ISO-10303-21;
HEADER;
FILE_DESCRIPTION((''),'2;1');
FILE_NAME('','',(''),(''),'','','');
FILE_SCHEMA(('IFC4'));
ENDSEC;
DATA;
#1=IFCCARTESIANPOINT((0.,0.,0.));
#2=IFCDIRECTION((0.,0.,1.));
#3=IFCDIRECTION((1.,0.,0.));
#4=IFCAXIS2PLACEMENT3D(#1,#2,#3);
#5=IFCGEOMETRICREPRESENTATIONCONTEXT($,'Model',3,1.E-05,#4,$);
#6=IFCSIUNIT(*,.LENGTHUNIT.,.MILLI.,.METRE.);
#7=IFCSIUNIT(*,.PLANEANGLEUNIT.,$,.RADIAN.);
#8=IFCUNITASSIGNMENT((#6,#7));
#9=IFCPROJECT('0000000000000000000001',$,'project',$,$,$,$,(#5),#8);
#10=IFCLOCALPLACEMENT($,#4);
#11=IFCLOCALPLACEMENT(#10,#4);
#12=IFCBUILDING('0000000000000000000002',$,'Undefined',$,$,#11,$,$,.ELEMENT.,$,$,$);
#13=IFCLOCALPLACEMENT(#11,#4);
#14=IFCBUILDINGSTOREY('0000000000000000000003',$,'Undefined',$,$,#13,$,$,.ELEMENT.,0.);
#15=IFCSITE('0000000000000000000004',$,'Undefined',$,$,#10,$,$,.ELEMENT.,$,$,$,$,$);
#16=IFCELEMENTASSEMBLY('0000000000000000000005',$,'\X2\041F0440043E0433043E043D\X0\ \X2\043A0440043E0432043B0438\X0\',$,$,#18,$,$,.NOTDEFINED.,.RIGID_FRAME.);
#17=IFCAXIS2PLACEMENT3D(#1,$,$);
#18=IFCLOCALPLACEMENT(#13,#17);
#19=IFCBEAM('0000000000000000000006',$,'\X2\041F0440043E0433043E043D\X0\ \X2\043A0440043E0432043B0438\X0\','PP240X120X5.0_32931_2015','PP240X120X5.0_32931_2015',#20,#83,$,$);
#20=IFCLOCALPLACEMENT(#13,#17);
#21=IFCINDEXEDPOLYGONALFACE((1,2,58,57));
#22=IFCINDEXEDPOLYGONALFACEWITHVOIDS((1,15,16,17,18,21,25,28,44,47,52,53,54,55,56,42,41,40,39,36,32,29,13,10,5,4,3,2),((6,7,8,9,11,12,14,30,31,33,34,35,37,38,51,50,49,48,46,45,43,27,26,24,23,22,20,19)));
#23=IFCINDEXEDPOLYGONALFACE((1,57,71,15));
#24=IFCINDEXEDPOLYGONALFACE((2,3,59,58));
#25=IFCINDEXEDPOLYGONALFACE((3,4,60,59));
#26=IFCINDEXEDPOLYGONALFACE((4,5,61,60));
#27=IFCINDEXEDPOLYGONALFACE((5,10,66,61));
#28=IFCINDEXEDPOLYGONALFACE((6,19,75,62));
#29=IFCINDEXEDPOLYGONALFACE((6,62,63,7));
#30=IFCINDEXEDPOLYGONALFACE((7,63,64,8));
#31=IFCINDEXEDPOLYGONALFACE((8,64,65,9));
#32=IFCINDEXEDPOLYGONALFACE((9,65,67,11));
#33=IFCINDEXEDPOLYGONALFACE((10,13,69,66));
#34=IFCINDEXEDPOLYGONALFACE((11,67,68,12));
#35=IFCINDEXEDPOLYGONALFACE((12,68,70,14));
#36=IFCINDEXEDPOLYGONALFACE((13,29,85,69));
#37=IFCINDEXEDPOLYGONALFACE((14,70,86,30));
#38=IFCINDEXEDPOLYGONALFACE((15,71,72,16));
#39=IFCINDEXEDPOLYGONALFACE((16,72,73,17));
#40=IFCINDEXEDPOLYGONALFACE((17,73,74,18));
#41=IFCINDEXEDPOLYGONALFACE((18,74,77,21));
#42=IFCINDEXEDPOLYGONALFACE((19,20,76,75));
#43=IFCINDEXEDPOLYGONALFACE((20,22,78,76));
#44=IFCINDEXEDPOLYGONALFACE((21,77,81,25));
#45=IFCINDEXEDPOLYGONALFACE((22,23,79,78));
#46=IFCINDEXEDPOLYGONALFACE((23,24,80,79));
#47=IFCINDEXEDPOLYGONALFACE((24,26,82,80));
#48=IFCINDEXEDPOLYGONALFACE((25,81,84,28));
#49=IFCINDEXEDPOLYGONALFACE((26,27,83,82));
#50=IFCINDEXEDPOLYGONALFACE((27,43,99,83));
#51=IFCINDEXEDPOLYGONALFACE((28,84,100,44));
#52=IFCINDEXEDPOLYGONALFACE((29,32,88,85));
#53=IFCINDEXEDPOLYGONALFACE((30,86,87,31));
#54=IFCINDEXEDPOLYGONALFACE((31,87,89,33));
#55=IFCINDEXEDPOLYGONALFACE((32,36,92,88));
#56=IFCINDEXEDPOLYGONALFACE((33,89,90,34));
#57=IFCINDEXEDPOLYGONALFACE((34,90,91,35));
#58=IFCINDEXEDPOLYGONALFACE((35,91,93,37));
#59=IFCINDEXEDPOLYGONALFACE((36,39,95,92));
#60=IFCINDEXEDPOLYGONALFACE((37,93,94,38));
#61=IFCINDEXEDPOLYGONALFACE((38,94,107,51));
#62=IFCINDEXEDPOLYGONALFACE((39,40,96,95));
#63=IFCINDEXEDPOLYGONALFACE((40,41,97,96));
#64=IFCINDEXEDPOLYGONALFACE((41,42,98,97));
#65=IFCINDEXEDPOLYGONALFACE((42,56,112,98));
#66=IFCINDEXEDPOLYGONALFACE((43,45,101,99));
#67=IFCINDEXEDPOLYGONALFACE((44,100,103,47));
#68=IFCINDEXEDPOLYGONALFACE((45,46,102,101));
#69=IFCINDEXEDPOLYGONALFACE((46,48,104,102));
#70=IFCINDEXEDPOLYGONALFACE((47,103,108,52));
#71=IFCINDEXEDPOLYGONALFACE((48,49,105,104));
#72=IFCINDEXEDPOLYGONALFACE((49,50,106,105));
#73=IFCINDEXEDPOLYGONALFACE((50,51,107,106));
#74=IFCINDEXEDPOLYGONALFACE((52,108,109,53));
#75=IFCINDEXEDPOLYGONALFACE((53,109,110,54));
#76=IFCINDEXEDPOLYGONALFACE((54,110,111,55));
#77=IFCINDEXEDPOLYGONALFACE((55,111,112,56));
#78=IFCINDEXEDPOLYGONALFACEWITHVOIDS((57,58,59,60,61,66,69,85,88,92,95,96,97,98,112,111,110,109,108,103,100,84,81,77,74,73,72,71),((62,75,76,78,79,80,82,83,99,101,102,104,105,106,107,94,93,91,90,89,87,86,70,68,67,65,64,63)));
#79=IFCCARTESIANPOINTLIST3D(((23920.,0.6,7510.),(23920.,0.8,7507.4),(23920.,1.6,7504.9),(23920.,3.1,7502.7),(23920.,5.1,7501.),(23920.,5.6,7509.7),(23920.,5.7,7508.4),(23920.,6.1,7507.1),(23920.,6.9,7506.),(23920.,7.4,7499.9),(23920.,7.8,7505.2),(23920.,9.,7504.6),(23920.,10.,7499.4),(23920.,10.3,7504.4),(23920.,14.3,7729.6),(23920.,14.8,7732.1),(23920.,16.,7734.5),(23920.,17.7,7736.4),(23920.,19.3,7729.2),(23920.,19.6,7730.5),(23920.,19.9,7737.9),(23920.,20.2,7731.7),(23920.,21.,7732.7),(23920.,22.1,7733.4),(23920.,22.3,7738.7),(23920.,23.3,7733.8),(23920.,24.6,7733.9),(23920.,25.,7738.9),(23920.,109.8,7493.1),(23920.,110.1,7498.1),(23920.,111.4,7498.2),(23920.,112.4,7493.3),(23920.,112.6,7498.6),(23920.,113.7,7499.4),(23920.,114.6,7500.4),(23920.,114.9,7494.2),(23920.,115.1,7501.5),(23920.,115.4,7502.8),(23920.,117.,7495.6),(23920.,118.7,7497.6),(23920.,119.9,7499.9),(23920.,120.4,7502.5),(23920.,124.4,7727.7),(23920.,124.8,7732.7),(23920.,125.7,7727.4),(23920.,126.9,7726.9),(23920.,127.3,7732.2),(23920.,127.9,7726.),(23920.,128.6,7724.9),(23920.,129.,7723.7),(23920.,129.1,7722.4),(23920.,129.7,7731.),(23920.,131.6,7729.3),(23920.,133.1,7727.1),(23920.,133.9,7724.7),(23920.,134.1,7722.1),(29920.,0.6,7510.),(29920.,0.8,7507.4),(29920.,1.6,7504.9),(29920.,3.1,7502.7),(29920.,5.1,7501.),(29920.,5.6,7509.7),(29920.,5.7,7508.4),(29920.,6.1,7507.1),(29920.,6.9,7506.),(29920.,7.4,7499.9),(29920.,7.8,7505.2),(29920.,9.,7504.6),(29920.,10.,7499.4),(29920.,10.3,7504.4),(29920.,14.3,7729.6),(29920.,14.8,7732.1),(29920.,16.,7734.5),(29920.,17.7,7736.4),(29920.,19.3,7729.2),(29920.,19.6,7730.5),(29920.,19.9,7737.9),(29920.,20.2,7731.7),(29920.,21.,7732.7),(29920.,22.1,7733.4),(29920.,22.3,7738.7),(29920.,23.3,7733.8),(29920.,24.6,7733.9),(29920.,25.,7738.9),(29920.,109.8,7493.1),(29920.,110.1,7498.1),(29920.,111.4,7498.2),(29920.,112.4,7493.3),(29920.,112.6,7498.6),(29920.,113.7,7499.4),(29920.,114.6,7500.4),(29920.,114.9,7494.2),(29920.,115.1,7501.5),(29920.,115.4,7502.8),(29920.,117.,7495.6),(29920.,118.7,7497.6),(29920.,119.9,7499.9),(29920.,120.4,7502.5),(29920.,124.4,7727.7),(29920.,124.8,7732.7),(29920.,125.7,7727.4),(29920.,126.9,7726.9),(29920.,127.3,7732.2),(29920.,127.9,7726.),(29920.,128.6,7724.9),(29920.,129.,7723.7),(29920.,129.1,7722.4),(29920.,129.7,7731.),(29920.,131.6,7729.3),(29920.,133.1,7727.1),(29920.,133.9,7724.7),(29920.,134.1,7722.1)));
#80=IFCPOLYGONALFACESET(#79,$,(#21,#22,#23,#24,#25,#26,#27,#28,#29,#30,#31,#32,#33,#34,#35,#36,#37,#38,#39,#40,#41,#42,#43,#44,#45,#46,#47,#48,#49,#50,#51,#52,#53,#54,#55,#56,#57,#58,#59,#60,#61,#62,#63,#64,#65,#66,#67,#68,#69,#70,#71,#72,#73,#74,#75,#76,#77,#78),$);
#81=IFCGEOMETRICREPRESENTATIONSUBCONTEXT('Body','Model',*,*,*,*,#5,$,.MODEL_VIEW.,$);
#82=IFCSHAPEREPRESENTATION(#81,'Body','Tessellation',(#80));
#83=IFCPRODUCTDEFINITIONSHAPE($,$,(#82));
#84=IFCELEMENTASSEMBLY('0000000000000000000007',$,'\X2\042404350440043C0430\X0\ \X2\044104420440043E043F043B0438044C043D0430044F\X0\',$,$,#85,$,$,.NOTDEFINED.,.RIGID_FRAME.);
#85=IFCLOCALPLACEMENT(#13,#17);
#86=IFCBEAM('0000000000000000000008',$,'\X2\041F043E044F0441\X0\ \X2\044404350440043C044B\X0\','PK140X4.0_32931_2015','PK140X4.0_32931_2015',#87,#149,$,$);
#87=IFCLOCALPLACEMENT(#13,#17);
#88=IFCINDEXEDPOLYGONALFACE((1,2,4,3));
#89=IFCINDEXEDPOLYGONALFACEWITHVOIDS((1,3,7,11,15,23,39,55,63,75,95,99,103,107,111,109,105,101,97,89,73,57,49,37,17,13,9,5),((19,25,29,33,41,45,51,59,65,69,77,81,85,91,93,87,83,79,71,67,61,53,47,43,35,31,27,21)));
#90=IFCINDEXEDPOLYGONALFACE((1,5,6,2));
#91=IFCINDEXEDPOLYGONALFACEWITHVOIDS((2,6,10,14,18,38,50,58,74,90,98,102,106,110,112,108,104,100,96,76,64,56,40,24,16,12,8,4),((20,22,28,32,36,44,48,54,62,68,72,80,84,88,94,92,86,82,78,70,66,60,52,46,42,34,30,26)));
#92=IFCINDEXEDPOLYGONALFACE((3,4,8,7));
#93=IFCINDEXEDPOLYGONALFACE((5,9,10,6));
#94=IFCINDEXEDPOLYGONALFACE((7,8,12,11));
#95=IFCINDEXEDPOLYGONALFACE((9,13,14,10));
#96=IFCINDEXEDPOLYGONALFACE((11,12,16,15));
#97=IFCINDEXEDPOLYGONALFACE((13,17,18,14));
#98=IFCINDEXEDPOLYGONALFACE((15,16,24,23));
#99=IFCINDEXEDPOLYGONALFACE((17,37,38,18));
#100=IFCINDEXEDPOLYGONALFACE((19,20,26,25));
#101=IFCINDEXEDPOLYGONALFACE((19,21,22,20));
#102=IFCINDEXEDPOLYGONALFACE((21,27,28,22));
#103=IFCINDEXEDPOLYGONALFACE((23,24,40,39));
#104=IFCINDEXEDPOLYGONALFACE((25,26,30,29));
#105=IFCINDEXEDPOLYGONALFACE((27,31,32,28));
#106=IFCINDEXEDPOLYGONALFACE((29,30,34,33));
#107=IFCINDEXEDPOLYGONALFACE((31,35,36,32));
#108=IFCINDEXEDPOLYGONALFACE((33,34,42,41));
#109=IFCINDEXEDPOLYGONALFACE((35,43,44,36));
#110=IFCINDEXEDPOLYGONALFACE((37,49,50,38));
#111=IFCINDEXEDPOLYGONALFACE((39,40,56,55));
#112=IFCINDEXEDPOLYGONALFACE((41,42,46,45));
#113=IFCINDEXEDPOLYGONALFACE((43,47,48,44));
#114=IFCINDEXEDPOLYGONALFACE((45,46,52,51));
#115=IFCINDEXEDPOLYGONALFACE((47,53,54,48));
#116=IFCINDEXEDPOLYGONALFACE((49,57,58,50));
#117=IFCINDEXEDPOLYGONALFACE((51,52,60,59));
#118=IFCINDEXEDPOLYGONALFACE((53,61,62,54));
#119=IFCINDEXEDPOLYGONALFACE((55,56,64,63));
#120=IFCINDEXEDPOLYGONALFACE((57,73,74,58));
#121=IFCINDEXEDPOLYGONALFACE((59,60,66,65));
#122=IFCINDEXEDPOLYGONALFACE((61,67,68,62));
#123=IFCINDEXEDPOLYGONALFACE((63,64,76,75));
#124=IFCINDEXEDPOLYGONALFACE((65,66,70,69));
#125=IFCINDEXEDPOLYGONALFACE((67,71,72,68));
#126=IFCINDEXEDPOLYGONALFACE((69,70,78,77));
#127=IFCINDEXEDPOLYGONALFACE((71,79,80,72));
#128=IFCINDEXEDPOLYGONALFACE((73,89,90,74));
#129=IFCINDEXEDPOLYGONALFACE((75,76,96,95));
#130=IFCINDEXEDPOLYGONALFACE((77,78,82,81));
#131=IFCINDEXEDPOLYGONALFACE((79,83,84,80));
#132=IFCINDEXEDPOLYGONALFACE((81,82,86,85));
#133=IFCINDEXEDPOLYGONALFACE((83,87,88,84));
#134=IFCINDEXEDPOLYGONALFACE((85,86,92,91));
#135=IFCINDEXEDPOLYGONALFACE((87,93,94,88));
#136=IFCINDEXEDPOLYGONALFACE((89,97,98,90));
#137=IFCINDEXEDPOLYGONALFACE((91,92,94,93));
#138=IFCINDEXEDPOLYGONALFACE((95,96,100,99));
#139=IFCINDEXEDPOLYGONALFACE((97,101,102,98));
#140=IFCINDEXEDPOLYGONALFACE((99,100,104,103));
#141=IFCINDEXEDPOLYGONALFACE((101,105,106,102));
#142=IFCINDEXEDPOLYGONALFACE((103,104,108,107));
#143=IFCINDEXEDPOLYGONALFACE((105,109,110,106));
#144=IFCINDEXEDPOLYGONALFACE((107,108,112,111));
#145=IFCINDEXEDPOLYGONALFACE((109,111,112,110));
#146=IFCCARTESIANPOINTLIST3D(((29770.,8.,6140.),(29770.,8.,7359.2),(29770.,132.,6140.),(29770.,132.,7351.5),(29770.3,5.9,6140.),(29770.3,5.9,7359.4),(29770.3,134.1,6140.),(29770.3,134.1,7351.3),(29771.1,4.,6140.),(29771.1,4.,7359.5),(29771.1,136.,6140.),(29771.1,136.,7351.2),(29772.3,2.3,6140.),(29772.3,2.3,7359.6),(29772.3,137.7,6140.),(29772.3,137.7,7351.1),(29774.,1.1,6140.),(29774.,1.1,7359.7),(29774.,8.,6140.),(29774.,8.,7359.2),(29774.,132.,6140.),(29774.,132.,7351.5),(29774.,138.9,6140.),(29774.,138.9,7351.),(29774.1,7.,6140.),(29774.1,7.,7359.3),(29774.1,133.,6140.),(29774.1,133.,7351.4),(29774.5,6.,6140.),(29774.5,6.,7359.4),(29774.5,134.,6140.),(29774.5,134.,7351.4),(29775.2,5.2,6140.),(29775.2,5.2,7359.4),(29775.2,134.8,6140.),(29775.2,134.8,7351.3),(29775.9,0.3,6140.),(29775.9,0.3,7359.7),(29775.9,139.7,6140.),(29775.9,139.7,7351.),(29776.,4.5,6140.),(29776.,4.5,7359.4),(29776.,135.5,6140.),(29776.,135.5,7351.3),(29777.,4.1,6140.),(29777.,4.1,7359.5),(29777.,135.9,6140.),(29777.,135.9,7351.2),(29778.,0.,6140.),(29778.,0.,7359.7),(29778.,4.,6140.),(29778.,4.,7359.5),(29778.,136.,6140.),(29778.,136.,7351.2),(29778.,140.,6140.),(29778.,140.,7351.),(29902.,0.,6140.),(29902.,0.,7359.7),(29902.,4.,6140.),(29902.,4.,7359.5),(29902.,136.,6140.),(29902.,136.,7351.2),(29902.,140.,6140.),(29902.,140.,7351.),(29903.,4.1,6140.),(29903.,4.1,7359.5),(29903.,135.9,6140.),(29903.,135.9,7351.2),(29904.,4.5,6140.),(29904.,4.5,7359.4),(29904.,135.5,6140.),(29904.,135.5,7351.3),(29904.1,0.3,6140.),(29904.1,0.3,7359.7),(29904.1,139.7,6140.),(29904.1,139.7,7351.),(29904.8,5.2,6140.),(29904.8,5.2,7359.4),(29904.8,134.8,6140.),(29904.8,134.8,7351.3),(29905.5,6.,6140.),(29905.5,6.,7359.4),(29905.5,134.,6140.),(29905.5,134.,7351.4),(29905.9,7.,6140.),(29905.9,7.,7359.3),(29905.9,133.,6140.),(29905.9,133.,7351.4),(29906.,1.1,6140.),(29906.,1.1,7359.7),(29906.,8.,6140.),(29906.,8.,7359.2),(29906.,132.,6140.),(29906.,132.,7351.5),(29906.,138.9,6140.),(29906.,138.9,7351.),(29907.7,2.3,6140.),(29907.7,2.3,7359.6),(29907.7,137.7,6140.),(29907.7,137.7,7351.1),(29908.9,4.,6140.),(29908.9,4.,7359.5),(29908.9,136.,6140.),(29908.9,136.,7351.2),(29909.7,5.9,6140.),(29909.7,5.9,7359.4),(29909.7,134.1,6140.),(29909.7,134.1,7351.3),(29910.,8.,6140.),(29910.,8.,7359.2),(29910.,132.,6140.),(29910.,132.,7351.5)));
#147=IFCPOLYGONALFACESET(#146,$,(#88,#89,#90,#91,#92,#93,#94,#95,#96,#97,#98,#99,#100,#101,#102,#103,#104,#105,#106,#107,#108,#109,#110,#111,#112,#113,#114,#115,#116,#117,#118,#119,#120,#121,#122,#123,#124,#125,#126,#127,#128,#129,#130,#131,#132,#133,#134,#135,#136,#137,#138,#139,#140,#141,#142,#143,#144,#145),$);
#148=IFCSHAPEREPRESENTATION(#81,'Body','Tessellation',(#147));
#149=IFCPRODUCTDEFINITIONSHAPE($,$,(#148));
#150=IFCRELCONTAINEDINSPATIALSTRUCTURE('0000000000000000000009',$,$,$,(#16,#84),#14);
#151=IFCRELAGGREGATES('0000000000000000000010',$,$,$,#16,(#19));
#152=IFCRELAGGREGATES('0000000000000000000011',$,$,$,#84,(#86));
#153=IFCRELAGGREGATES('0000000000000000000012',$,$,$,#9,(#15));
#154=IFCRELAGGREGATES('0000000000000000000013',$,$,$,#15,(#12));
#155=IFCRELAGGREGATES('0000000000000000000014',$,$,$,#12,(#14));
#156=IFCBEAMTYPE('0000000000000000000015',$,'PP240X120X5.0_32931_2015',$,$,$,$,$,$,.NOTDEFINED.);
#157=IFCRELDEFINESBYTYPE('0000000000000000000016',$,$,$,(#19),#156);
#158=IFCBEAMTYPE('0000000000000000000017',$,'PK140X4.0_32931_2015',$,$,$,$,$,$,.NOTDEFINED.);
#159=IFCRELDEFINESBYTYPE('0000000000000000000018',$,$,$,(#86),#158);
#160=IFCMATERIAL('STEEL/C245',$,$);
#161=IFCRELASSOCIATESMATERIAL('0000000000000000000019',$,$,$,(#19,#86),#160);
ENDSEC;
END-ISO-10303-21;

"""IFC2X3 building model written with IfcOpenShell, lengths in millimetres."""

from ifc_helpers import new_model, si_unit, frame, origin_with_axes, origin_2d_with_axis, place, context, subcontext, project, spatial, hollow_rectangle, extrude, clip, halfspace, material, type_object, element, aggregate, save


model = new_model("IFC2X3")

# Units and contexts
model_context = context("Model", 3, precision=1e-05, world=origin_with_axes())
body_context = subcontext(model_context, "Body", "Model", "MODEL_VIEW")
ifc_project = project(units=[si_unit("LENGTHUNIT", "METRE", prefix="MILLI"), si_unit("PLANEANGLEUNIT", "RADIAN")], contexts=[model_context])

# Site, building, storey
site_placement = place(None, origin_with_axes())
site = spatial("IfcSite", under=ifc_project, at=site_placement, Name="Undefined", CompositionType="ELEMENT")
building_placement = place(site_placement, origin_with_axes())
building = spatial("IfcBuilding", under=site, at=building_placement, Name="Undefined", CompositionType="ELEMENT")
storey_placement = place(building_placement, origin_with_axes())
storey = spatial("IfcBuildingStorey", under=building, at=storey_placement, Name="Undefined", CompositionType="ELEMENT", Elevation=0.0)

# Shared definitions
ifc_material = material(Name="STEEL/C245")

# Element assembly, beam
beam_type_1 = type_object("IfcBeamType", Name="PP240X120X5.0_32931_2015", PredefinedType="NOTDEFINED")
assembly_1_placement = place(storey_placement, origin_with_axes())
assembly_1 = element("IfcElementAssembly", 1, at=assembly_1_placement, inside=storey, Name="Прогон кровли", AssemblyPlace="NOTDEFINED", PredefinedType="RIGID_FRAME")
beam_1_placement = place(assembly_1_placement, frame((29920.0, 67.4, 7616.0), z_axis=(0.0, 0.062378, 0.998053), x_axis=(-1.0, 0.0, 0.0)))
beam_1 = element("IfcBeam", 2, at=beam_1_placement, type_object=beam_type_1, material=ifc_material, Name="Прогон кровли", Description="PP240X120X5.0_32931_2015", ObjectType="PP240X120X5.0_32931_2015", context=body_context, shape_type="SweptSolid", body=[
    extrude(hollow_rectangle(XDim=120.0, YDim=240.0, WallThickness=5.0, InnerFilletRadius=5.0, OuterFilletRadius=10.0, at=origin_2d_with_axis()), frame((6000.0, 0.0, 0.0), z_axis=(-1.0, 0.0, 0.0), x_axis=(0.0, -1.0, 0.0)), (0.0, 0.0, 1.0), 6000.0),
])
aggregate(assembly_1, [beam_1])

# Element assembly
assembly_2_placement = place(storey_placement, origin_with_axes())
assembly_2 = element("IfcElementAssembly", 3, at=assembly_2_placement, inside=storey, Name="Ферма строплиьная", AssemblyPlace="NOTDEFINED", PredefinedType="RIGID_FRAME")

# Beam
beam_type_2 = type_object("IfcBeamType", Name="PK140X4.0_32931_2015", PredefinedType="NOTDEFINED")
beam_2_placement = place(assembly_2_placement, frame((29840.0, 70.0, 7359.7), z_axis=(1.0, 0.0, 0.0), x_axis=(0.0, 0.0, -1.0)))
beam_2 = element("IfcBeam", 4, at=beam_2_placement, type_object=beam_type_2, material=ifc_material, Name="Пояс фермы", Description="PK140X4.0_32931_2015", ObjectType="PK140X4.0_32931_2015", context=body_context, shape_type="Clipping", body=[
    clip(extrude(hollow_rectangle(XDim=140.0, YDim=140.0, WallThickness=4.0, InnerFilletRadius=4.0, OuterFilletRadius=8.0, at=origin_2d_with_axis()), frame((1219.7, 0.0, 0.0), z_axis=(-1.0, 0.0, 0.0), x_axis=(0.0, -1.0, 0.0)), (0.0, 0.0, 1.0), 1219.8), halfspace(frame((10.5, 98.4, 0.0), z_axis=(0.998053, -0.062378, 0.0), x_axis=(0.0, 0.0, 1.0)), True)),
])
aggregate(assembly_2, [beam_2])

save(model, "model.ifc")
